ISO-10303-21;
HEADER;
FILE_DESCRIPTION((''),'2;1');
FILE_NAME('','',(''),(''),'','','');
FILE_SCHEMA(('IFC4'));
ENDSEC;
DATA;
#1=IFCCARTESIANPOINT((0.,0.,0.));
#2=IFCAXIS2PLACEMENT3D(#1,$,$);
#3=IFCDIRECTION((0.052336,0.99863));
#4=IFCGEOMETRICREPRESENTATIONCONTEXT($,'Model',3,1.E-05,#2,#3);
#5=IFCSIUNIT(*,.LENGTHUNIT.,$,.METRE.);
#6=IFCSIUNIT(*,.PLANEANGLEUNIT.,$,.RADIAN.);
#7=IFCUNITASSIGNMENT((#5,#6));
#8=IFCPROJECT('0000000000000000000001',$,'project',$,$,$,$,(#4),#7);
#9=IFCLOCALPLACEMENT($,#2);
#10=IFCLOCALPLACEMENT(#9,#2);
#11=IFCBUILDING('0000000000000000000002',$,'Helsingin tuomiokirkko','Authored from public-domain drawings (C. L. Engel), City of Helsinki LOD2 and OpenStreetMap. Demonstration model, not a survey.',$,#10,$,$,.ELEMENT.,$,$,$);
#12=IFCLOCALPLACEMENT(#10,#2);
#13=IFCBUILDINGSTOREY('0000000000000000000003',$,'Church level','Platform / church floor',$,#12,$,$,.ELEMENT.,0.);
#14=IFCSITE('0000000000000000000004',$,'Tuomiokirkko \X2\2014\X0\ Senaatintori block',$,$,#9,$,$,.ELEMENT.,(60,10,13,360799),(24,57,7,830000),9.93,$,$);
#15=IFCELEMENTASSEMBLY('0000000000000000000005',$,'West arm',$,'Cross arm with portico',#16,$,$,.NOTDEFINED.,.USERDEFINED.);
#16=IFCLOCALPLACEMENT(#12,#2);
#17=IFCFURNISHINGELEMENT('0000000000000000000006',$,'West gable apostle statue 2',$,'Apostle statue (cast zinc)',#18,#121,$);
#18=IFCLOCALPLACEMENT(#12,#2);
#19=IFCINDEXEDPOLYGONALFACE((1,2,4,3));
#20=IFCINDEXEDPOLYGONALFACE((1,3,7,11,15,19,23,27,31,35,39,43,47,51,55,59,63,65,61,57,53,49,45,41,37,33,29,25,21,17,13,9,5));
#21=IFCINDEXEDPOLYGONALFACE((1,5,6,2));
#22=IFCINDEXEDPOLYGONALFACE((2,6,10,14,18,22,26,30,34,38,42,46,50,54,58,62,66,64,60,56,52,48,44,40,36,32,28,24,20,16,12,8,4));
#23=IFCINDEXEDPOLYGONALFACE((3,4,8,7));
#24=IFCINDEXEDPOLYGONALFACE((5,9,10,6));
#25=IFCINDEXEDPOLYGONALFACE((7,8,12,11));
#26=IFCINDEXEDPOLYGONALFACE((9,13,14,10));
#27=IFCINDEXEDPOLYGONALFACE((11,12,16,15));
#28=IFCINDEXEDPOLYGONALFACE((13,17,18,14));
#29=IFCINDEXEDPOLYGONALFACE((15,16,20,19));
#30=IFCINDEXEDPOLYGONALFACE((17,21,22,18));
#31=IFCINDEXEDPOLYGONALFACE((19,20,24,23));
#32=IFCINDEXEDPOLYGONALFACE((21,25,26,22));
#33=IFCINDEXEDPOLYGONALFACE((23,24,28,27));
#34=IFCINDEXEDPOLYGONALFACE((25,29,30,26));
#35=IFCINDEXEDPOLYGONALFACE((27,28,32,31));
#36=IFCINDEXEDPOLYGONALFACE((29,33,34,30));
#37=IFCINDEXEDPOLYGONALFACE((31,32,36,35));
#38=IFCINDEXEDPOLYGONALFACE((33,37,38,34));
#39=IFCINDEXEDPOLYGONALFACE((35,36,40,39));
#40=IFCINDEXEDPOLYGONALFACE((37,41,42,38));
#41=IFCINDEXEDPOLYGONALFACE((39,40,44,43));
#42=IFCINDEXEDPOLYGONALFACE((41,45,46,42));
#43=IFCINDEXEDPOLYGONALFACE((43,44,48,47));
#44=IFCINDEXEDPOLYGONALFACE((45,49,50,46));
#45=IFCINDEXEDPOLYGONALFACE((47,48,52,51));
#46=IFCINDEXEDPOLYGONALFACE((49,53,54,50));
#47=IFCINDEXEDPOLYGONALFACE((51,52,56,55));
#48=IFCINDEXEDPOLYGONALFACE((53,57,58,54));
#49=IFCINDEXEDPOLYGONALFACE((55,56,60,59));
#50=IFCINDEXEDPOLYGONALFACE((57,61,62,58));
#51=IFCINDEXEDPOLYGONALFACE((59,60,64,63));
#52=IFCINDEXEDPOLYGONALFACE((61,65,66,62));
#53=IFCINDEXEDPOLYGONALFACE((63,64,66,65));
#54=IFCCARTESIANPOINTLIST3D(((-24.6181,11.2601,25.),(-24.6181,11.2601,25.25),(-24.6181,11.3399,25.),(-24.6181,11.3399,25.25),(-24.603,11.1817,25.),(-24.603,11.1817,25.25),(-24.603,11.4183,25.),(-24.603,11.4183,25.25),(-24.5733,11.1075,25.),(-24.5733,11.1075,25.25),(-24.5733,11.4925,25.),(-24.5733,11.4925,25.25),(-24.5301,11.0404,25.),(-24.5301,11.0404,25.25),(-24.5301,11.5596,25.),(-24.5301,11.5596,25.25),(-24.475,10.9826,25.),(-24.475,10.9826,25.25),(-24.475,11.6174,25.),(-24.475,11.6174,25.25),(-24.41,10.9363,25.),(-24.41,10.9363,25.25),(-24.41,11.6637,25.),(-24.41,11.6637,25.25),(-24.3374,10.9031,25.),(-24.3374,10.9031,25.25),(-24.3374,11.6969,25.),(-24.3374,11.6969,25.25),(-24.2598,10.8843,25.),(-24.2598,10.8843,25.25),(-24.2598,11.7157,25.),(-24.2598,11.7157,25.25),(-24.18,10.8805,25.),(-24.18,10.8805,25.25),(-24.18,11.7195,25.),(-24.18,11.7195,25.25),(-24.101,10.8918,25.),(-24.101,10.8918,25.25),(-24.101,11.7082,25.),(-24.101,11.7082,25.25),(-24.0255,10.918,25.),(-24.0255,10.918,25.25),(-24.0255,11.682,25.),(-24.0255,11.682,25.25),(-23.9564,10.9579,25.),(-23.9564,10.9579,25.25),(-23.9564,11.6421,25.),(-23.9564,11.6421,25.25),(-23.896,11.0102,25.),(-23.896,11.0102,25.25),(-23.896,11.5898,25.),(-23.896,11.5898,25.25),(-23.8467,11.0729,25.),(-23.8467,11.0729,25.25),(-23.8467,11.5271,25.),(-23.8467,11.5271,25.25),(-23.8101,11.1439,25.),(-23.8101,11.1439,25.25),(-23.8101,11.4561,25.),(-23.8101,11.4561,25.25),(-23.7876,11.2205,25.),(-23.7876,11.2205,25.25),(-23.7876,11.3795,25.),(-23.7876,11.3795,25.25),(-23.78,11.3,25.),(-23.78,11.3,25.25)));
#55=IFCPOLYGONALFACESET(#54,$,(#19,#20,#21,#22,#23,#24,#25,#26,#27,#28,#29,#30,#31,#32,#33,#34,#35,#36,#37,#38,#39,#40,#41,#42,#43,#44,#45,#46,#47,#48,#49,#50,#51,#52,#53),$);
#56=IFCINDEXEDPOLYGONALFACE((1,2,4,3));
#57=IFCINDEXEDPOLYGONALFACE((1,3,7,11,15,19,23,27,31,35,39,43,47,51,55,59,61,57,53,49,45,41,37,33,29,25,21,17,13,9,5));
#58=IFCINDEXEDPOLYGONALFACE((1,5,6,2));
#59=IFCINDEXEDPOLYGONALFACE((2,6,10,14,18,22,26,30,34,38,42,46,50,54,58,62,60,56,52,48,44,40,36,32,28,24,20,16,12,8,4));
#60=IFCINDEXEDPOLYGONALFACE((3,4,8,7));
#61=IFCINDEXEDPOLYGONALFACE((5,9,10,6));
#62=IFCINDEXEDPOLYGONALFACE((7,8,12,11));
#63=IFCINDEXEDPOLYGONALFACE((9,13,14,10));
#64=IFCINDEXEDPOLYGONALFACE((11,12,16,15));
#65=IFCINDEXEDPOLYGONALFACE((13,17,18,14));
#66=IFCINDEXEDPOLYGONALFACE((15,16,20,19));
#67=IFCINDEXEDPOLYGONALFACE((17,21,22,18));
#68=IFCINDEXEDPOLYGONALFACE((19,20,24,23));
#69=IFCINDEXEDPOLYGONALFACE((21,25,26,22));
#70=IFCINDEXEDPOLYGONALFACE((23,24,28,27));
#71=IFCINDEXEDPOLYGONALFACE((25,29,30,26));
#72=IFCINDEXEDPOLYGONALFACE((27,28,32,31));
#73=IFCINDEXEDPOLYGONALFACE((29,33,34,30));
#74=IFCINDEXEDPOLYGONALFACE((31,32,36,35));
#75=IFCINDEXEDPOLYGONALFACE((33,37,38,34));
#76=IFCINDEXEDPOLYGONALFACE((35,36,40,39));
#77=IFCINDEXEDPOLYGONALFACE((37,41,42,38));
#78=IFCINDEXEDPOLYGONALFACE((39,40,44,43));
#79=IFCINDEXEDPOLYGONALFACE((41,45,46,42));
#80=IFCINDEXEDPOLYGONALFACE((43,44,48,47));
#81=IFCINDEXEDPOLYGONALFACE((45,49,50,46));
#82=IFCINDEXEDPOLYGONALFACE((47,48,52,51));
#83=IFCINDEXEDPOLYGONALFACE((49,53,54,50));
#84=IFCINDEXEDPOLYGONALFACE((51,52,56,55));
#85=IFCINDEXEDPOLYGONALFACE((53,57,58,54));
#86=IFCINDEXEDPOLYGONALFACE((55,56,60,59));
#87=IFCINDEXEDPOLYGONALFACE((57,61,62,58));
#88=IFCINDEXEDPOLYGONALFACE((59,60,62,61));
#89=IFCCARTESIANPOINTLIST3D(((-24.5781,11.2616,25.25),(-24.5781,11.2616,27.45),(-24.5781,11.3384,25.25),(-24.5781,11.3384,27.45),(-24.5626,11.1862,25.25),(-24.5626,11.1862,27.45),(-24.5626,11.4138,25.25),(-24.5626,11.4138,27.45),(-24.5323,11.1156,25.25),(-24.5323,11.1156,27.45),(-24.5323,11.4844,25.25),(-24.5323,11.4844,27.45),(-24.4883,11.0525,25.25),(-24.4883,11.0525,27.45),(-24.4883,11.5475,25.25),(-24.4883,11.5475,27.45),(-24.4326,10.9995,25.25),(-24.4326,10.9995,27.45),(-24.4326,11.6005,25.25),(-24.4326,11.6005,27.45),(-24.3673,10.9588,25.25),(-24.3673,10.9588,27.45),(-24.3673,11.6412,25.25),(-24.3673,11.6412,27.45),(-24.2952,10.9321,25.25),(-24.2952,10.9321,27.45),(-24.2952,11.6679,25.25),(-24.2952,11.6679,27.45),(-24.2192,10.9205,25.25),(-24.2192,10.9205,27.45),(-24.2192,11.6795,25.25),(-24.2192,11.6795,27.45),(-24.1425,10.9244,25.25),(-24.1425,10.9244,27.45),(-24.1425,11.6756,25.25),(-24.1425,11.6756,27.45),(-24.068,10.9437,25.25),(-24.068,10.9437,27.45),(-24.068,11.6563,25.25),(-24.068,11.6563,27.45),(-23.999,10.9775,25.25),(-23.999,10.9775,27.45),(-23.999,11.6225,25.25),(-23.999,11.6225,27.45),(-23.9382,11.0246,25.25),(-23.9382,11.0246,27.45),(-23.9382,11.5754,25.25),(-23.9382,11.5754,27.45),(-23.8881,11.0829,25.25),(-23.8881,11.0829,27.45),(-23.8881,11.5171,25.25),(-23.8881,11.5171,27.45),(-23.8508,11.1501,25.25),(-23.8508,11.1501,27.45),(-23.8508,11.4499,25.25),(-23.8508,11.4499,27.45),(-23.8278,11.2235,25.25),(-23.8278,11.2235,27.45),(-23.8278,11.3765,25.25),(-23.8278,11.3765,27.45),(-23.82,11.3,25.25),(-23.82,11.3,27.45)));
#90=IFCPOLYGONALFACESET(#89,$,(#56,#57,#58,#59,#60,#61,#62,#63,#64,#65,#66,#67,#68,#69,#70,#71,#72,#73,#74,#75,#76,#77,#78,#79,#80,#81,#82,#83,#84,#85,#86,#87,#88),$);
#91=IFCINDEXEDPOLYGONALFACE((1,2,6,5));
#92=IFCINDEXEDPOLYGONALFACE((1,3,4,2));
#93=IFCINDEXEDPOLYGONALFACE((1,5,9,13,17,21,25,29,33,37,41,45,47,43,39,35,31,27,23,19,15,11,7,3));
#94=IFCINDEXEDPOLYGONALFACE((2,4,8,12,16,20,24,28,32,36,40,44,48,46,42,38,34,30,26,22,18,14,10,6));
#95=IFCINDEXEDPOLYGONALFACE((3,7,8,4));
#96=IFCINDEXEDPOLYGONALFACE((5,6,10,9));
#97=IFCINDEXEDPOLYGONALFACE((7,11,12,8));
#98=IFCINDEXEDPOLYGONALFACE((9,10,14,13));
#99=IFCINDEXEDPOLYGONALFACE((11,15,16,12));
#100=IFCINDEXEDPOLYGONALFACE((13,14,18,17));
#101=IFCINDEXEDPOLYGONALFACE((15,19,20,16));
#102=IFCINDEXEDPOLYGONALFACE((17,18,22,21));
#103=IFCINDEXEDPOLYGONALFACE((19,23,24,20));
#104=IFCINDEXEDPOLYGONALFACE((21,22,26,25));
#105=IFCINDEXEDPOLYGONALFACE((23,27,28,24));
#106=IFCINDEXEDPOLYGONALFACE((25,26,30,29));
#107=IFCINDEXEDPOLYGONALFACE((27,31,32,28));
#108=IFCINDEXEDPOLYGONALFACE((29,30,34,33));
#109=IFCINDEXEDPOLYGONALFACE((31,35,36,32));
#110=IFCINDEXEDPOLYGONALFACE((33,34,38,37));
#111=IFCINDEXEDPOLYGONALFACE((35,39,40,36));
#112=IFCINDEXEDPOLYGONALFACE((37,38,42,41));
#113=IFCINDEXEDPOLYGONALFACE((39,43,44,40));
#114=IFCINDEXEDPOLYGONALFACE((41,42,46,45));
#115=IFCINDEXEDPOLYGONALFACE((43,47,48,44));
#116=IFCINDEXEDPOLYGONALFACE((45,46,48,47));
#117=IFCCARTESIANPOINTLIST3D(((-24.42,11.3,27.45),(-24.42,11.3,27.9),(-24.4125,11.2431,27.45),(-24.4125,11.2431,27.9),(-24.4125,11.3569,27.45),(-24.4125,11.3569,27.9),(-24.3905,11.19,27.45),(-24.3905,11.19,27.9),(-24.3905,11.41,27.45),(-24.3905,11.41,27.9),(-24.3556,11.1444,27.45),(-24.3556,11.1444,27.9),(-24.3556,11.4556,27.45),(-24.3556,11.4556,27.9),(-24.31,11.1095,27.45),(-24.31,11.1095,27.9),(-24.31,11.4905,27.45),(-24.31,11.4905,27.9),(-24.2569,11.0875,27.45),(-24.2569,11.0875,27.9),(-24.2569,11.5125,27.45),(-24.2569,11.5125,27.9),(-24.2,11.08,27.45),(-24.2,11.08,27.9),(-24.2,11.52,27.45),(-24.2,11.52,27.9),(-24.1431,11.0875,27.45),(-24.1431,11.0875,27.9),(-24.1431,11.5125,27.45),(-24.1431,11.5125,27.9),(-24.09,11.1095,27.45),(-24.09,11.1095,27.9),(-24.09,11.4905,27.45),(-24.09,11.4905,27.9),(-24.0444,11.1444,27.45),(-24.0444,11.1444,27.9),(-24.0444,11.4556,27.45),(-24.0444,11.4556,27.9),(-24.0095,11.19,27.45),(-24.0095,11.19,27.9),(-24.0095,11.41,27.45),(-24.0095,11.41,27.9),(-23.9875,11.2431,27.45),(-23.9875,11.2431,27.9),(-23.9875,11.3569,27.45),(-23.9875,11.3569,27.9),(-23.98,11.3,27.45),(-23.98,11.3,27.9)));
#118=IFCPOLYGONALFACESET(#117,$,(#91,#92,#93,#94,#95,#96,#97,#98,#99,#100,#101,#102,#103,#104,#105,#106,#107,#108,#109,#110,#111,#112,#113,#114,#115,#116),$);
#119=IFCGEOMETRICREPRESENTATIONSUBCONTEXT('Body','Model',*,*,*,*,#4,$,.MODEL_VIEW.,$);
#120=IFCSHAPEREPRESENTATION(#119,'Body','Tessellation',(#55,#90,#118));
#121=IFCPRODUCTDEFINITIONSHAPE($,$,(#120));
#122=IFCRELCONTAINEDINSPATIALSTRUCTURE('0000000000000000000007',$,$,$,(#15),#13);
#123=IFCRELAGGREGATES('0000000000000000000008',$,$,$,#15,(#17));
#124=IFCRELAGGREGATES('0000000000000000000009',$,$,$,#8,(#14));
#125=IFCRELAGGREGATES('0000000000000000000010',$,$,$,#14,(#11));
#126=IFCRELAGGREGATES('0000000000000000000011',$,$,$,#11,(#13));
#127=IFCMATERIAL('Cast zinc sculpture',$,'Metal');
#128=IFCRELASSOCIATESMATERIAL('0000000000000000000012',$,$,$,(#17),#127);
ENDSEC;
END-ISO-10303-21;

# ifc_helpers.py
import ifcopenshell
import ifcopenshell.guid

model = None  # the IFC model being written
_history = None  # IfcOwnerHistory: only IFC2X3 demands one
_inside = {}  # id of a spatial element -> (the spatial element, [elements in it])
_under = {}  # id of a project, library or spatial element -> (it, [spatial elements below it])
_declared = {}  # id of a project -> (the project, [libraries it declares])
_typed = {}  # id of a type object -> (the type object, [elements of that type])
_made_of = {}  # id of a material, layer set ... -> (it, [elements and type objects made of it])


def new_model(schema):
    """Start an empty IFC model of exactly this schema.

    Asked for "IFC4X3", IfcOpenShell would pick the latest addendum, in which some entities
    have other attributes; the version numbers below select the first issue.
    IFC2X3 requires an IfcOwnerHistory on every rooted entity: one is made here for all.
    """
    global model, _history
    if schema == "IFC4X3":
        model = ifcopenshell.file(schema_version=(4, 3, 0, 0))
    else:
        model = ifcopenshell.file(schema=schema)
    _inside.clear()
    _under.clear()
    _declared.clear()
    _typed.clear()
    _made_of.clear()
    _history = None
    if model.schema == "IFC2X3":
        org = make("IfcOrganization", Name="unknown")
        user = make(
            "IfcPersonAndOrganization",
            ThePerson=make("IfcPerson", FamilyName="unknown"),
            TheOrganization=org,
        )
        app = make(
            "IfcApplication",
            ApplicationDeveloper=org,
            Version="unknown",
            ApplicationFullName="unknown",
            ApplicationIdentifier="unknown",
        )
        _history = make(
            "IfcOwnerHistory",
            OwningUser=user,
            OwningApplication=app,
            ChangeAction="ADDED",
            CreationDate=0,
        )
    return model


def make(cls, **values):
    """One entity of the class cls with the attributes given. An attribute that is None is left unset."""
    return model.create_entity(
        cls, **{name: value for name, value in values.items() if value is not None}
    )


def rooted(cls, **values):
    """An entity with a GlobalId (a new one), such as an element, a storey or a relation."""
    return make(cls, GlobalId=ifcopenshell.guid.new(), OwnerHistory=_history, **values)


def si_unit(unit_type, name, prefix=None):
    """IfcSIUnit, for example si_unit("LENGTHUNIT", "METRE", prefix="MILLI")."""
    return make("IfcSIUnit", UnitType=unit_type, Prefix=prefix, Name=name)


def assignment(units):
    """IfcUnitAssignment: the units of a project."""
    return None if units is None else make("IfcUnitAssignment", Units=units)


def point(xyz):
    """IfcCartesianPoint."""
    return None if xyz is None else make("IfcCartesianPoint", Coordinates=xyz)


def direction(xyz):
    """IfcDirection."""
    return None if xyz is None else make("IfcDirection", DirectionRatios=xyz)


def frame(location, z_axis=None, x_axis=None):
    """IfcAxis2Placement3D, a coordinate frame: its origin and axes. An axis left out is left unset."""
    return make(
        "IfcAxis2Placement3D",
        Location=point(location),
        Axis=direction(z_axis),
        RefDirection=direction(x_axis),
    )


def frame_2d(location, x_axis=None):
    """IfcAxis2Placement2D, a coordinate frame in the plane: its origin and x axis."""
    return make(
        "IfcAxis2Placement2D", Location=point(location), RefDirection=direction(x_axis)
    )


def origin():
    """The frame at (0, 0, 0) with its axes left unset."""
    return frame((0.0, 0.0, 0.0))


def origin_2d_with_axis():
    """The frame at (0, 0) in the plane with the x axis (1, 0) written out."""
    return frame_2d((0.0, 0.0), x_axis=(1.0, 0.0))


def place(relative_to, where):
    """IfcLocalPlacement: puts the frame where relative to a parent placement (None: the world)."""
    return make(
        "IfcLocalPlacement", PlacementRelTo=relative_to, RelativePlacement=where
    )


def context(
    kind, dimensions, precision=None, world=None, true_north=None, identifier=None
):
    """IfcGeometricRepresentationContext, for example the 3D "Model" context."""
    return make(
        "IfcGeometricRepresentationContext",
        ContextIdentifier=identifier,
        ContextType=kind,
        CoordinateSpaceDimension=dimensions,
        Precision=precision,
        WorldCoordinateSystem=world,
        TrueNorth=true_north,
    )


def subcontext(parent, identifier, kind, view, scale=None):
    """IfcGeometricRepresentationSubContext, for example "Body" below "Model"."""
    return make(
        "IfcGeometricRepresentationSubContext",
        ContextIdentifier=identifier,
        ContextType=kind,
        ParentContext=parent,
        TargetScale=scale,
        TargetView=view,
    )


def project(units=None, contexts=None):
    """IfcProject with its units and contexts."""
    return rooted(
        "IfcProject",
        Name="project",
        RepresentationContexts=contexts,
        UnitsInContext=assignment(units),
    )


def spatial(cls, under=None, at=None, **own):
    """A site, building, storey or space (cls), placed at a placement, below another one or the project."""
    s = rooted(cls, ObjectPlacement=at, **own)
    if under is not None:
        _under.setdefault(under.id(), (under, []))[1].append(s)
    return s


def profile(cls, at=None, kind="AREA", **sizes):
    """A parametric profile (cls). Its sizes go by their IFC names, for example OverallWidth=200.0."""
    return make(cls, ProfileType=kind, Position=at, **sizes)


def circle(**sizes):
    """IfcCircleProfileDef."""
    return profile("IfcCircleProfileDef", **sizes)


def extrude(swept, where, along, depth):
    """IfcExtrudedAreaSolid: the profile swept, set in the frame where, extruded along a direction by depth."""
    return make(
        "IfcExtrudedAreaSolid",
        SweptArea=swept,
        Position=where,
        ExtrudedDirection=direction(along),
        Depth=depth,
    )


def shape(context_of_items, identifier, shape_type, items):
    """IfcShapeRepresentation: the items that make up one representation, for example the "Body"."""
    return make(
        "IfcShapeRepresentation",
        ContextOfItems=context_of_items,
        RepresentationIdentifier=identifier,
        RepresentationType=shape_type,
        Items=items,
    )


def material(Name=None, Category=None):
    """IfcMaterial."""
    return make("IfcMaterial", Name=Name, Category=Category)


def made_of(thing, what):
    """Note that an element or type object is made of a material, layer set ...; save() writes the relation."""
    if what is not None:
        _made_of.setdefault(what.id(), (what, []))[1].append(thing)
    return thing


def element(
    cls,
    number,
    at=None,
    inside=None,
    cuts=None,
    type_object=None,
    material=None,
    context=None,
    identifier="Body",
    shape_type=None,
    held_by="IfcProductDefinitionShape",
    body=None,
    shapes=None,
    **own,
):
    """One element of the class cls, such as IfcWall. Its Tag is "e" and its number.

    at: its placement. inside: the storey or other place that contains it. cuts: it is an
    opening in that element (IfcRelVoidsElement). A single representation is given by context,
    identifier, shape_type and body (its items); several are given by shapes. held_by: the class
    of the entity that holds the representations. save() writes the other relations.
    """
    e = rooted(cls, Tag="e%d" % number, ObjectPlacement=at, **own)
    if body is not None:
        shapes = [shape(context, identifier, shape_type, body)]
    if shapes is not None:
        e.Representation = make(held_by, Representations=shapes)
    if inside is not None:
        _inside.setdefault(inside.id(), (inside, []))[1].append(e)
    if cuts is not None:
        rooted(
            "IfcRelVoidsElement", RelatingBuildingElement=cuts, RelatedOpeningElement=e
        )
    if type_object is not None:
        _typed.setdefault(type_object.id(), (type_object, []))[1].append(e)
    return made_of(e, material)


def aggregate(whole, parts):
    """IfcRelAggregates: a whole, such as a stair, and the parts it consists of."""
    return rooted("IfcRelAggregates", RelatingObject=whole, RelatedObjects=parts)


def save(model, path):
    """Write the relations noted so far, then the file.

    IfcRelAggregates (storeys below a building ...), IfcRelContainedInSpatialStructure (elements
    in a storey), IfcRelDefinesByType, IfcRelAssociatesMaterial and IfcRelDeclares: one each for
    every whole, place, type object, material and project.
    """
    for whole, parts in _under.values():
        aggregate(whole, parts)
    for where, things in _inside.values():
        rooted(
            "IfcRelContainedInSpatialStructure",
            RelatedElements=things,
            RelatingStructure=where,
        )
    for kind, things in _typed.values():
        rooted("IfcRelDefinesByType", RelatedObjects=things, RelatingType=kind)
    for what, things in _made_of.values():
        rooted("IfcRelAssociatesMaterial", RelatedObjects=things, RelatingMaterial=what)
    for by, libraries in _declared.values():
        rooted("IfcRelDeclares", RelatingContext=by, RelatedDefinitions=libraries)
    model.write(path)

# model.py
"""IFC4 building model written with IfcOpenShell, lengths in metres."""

from ifc_helpers import new_model, si_unit, direction, frame, origin, origin_2d_with_axis, place, context, subcontext, project, spatial, circle, extrude, material, element, aggregate, save


model = new_model("IFC4")

# Units and contexts
model_context = context("Model", 3, precision=1e-05, world=origin(), true_north=direction((0.052336, 0.99863)))
body_context = subcontext(model_context, "Body", "Model", "MODEL_VIEW")
ifc_project = project(units=[si_unit("LENGTHUNIT", "METRE"), si_unit("PLANEANGLEUNIT", "RADIAN")], contexts=[model_context])

# Site, building, storey
site_placement = place(None, origin())
site = spatial("IfcSite", under=ifc_project, at=site_placement, Name="Tuomiokirkko — Senaatintori block", CompositionType="ELEMENT", RefLatitude=(60, 10, 13, 360799), RefLongitude=(24, 57, 7, 830000), RefElevation=9.93)
building_placement = place(site_placement, origin())
building = spatial("IfcBuilding", under=site, at=building_placement, Name="Helsingin tuomiokirkko", Description="Authored from public-domain drawings (C. L. Engel), City of Helsinki LOD2 and OpenStreetMap. Demonstration model, not a survey.", CompositionType="ELEMENT")
storey_placement = place(building_placement, origin())
storey = spatial("IfcBuildingStorey", under=building, at=storey_placement, Name="Church level", Description="Platform / church floor", CompositionType="ELEMENT", Elevation=0.0)

# Element assembly
assembly_1_placement = place(building_placement, origin())
assembly_1 = element("IfcElementAssembly", 1, at=assembly_1_placement, inside=storey, Name="West arm", ObjectType="Cross arm with portico", AssemblyPlace="NOTDEFINED", PredefinedType="USERDEFINED")

# Furnishing element
ifc_material_1 = material(Name="Cast zinc sculpture", Category="Metal")
furnishing_1_placement = place(building_placement, origin())
furnishing_1 = element("IfcFurnishingElement", 2, at=furnishing_1_placement, material=ifc_material_1, Name="West gable apostle statue 2", ObjectType="Apostle statue (cast zinc)", context=body_context, shape_type="SweptSolid", body=[
    extrude(circle(Radius=0.42, at=origin_2d_with_axis()), frame((-24.2, 11.3, 25.0)), (0.0, 0.0, 1.0), 0.25),
    extrude(circle(Radius=0.38, at=origin_2d_with_axis()), frame((-24.2, 11.3, 25.25)), (0.0, 0.0, 1.0), 2.2),
    extrude(circle(Radius=0.22, at=origin_2d_with_axis()), frame((-24.2, 11.3, 27.45)), (0.0, 0.0, 1.0), 0.45),
])
aggregate(assembly_1, [furnishing_1])

save(model, "model.ifc")
